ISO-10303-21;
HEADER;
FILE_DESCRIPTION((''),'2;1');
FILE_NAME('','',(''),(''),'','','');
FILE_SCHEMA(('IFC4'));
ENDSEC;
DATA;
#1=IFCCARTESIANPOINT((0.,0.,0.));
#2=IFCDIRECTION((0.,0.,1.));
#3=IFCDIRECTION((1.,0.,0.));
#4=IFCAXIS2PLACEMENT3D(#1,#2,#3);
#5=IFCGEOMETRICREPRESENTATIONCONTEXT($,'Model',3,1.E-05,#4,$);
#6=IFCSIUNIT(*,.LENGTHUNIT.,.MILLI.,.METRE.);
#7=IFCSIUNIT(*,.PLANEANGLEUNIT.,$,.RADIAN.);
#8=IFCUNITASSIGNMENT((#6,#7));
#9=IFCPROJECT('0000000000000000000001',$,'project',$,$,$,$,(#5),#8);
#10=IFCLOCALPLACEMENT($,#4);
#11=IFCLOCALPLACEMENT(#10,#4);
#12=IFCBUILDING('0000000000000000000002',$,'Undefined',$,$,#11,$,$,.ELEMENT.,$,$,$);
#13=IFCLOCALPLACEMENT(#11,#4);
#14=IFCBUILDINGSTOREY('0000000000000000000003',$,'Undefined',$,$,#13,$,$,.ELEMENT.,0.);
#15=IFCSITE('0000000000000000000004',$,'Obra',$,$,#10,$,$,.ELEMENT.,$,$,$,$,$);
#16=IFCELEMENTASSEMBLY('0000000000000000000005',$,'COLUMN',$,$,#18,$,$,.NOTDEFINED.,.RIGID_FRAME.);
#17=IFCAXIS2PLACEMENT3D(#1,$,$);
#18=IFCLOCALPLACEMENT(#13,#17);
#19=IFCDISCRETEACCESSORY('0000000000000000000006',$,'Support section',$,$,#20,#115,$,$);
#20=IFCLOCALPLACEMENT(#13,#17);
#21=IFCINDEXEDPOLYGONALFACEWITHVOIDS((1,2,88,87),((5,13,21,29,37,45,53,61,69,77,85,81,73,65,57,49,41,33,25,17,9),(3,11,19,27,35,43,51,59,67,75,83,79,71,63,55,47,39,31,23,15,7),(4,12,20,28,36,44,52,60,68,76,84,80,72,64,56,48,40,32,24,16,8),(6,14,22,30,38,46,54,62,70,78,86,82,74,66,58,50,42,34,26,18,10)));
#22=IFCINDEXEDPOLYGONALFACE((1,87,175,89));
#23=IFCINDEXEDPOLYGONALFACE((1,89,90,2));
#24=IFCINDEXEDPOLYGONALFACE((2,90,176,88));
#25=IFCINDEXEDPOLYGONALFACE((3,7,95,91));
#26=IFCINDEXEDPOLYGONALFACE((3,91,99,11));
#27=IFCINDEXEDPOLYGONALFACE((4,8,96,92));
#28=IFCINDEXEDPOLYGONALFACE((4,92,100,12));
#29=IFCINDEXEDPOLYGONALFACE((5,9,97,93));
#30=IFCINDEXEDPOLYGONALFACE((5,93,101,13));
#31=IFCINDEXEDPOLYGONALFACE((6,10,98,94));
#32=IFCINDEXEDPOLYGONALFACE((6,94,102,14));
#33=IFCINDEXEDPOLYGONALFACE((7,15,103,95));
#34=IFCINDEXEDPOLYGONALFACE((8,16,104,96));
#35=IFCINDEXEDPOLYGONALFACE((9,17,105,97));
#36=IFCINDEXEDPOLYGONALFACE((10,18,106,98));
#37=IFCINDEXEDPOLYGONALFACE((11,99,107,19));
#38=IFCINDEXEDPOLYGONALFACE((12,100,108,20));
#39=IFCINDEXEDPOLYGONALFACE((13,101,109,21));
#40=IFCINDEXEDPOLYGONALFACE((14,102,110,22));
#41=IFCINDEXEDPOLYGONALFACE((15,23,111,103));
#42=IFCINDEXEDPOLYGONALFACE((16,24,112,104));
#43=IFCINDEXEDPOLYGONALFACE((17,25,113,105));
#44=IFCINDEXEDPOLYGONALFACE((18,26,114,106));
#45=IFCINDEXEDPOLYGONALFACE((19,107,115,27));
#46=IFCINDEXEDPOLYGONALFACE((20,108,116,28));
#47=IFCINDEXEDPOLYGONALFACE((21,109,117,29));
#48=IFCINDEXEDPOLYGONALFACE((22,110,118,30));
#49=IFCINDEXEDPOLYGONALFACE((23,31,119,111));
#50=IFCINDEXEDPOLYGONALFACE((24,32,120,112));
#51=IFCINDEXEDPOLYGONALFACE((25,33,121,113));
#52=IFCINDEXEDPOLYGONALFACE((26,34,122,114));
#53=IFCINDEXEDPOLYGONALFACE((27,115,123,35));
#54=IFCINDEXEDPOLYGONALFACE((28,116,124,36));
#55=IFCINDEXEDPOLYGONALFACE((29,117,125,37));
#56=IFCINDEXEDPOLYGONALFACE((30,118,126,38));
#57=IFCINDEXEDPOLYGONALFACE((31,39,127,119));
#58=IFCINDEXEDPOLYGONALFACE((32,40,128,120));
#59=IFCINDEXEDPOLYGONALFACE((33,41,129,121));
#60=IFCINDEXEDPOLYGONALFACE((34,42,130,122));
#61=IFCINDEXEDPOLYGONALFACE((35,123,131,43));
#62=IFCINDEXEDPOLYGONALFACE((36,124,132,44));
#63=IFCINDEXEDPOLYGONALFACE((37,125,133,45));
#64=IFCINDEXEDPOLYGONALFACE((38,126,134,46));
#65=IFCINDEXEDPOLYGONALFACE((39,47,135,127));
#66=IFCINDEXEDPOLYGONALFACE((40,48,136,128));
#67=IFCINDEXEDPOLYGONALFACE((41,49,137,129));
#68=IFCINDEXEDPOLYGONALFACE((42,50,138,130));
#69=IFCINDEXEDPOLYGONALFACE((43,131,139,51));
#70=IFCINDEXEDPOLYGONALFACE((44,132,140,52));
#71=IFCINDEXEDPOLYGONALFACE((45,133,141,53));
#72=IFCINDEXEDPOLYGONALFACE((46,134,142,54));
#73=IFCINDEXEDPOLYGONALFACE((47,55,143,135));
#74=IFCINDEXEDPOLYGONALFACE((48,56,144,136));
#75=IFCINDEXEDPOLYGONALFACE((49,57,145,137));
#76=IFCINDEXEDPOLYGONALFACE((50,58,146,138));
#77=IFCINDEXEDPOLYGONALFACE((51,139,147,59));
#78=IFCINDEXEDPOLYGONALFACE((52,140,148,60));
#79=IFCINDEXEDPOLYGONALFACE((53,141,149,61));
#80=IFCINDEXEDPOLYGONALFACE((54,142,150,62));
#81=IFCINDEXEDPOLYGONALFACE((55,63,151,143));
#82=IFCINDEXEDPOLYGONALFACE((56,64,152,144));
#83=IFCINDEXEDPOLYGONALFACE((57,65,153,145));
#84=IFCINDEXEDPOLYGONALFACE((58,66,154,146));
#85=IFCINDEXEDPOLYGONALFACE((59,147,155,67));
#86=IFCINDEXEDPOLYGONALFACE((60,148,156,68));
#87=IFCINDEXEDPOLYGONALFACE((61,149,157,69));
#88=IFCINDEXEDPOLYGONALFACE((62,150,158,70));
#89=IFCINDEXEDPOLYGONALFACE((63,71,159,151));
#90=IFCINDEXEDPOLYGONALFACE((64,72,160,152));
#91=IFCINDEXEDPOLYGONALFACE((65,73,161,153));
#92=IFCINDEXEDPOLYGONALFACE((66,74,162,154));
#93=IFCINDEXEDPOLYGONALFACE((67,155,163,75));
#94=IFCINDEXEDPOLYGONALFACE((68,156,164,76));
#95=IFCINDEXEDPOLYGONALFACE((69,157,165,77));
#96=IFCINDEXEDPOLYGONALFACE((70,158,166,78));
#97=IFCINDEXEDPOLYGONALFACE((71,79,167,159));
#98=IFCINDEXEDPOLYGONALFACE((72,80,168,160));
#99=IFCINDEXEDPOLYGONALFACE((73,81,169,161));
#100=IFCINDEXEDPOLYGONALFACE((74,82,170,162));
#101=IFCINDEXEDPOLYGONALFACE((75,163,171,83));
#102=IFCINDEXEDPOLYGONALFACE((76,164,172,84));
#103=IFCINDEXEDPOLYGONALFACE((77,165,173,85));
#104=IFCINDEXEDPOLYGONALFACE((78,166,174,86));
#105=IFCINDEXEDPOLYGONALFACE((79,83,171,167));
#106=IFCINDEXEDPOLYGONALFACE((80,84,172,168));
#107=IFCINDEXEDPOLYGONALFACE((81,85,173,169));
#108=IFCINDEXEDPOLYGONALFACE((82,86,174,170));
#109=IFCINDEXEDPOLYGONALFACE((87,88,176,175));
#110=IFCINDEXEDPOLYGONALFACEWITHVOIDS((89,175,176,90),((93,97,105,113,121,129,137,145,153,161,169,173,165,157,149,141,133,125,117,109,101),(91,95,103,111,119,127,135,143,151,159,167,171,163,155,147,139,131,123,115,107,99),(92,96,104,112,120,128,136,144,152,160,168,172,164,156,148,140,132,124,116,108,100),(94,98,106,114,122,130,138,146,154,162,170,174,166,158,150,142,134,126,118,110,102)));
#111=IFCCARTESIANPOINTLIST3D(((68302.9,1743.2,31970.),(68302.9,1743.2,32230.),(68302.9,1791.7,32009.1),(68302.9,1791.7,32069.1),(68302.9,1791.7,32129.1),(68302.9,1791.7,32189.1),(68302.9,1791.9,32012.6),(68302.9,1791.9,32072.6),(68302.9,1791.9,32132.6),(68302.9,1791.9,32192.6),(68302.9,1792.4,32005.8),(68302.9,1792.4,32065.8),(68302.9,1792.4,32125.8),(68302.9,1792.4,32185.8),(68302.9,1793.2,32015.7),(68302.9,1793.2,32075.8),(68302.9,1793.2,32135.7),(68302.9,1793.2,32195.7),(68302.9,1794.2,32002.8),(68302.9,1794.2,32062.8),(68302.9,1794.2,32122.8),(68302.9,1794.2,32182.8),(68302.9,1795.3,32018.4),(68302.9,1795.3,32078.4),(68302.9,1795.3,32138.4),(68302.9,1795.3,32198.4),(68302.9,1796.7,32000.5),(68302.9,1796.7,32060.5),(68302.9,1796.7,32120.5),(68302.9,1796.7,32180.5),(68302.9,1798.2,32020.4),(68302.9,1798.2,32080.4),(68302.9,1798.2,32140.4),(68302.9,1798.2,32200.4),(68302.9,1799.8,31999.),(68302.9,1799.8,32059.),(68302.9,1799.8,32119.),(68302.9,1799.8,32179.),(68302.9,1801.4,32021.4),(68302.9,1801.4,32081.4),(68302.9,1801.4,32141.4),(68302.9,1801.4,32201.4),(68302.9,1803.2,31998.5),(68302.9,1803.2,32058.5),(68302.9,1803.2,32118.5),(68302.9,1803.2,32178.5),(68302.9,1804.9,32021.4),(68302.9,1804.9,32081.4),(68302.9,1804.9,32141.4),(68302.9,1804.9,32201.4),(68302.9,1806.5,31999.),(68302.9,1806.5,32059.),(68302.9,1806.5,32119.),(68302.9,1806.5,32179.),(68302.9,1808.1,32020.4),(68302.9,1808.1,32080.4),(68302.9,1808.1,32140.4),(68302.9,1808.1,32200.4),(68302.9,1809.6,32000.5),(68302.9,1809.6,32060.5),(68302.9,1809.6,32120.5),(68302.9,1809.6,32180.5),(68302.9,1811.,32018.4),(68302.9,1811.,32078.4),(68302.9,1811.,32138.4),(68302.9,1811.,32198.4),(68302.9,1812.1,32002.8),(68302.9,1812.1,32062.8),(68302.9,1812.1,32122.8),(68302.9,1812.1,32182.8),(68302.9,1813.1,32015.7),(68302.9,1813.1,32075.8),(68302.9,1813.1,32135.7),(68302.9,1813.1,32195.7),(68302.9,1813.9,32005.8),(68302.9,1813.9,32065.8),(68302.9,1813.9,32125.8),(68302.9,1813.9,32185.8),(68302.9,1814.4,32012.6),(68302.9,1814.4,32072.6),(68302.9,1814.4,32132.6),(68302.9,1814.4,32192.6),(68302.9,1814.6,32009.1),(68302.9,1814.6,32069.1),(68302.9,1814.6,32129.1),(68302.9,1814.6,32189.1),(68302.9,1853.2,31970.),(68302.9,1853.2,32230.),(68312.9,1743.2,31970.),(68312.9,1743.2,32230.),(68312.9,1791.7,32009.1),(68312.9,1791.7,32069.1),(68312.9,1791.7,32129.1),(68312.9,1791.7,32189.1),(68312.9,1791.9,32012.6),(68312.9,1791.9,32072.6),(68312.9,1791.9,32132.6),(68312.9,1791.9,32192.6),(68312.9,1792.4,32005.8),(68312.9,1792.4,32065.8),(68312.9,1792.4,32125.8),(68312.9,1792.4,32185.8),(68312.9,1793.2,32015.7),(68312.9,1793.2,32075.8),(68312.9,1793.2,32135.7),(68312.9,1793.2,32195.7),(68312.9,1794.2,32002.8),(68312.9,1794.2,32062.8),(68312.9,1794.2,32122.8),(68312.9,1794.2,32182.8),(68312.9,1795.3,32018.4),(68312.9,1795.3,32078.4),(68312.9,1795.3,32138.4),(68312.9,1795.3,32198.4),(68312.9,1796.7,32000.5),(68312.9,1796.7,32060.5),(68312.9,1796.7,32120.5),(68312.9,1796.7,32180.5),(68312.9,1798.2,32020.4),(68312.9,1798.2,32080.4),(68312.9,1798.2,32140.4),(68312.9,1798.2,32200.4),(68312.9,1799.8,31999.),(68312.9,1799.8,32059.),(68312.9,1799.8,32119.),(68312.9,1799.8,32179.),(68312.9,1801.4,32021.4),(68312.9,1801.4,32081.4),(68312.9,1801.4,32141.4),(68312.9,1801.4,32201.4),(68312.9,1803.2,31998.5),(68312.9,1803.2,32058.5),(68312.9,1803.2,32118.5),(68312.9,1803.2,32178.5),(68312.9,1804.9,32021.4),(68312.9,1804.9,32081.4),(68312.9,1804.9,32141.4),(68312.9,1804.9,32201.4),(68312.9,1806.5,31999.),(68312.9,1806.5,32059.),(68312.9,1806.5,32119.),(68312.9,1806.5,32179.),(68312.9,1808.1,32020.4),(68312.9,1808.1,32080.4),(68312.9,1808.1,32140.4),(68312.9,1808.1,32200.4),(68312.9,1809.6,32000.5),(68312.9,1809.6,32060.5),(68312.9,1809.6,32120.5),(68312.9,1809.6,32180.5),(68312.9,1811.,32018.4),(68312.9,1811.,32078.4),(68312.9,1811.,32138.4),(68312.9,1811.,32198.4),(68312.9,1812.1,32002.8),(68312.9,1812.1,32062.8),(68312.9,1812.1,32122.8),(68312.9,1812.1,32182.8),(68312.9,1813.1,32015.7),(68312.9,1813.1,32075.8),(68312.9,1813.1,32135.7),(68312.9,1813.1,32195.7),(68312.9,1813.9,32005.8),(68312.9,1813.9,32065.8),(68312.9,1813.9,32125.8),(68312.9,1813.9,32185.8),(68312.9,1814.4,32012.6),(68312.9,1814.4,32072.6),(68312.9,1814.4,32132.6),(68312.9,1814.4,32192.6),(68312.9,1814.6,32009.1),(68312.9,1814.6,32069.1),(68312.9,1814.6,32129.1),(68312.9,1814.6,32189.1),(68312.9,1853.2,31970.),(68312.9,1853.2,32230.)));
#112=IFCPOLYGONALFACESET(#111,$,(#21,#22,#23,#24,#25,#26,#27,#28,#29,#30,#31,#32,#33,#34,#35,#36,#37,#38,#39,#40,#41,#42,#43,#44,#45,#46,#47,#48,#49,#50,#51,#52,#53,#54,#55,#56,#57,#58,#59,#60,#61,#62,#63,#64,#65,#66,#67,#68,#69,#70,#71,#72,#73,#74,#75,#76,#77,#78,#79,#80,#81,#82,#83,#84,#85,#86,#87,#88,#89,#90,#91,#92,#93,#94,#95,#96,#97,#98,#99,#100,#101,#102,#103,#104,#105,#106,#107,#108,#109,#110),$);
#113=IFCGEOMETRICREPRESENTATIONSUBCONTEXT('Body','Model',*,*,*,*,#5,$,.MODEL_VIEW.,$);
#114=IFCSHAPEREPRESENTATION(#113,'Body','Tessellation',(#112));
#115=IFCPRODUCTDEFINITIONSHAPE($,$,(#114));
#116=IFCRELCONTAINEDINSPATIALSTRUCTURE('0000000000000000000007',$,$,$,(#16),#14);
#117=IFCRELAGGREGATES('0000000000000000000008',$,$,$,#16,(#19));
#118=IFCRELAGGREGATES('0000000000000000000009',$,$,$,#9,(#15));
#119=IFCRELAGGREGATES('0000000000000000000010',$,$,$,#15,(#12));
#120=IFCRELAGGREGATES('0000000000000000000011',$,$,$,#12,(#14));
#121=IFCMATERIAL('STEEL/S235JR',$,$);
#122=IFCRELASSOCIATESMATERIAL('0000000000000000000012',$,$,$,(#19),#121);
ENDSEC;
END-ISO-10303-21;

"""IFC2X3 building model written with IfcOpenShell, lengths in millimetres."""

from ifc_helpers import new_model, si_unit, frame, origin_with_axes, origin_2d_with_axis, place, context, subcontext, project, spatial, rectangle, circle, extrude, source, transform, mapped, material, element, aggregate, save


model = new_model("IFC2X3")

# Units and contexts
model_context = context("Model", 3, precision=1e-05, world=origin_with_axes())
body_context = subcontext(model_context, "Body", "Model", "MODEL_VIEW")
ifc_project = project(units=[si_unit("LENGTHUNIT", "METRE", prefix="MILLI"), si_unit("PLANEANGLEUNIT", "RADIAN")], contexts=[model_context])

# Site, building, storey
site_placement = place(None, origin_with_axes())
site = spatial("IfcSite", under=ifc_project, at=site_placement, Name="Obra", CompositionType="ELEMENT")
building_placement = place(site_placement, origin_with_axes())
building = spatial("IfcBuilding", under=site, at=building_placement, Name="Undefined", CompositionType="ELEMENT")
storey_placement = place(building_placement, origin_with_axes())
storey = spatial("IfcBuildingStorey", under=building, at=storey_placement, Name="Undefined", CompositionType="ELEMENT", Elevation=0.0)

# Element assembly
assembly_1_placement = place(storey_placement, origin_with_axes())
assembly_1 = element("IfcElementAssembly", 1, at=assembly_1_placement, inside=storey, Name="COLUMN", AssemblyPlace="NOTDEFINED", PredefinedType="RIGID_FRAME")
ifc_material_1 = material(Name="STEEL/S235JR")

# Discrete accessory, opening
shared_shape_1 = source(origin_with_axes(), body_context, "Body", "SweptSolid", [
    extrude(circle(Radius=11.5, at=origin_2d_with_axis()), frame((0.0, -14.4, 0.0), z_axis=(0.0, 1.0, 0.0), x_axis=(1.0, 0.0, 0.0)), (0.0, 0.0, 1.0), 10.2),
])
discrete_accessory_1_placement = place(assembly_1_placement, frame((68307.9, 1798.2, 31970.0), z_axis=(0.0, 0.0, 1.0), x_axis=(0.0, -1.0, 0.0)))
discrete_accessory_1 = element("IfcDiscreteAccessory", 2, at=discrete_accessory_1_placement, material=ifc_material_1, Name="Support section", context=body_context, shape_type="SweptSolid", body=[
    extrude(rectangle(XDim=10.0, YDim=110.0, at=origin_2d_with_axis()), frame((0.0, 0.0, 260.0), z_axis=(0.0, 0.0, -1.0), x_axis=(0.0, 1.0, 0.0)), (0.0, 0.0, 1.0), 260.0),
])
opening_1_placement = place(assembly_1_placement, frame((68298.6, 1753.2, 32300.0), z_axis=(0.0, 1.0, 0.0), x_axis=(0.0, 0.0, -1.0)))
element("IfcOpeningElement", 3, at=opening_1_placement, cuts=discrete_accessory_1, ObjectType="Opening", context=body_context, shape_type="MappedRepresentation", body=[
    mapped(shared_shape_1, transform((110.0, 0.0, 50.0))),
    mapped(shared_shape_1, transform((170.0, 0.0, 50.0))),
    mapped(shared_shape_1, transform((230.0, 0.0, 50.0))),
    mapped(shared_shape_1, transform((290.0, 0.0, 50.0))),
])
aggregate(assembly_1, [discrete_accessory_1])

save(model, "model.ifc")
